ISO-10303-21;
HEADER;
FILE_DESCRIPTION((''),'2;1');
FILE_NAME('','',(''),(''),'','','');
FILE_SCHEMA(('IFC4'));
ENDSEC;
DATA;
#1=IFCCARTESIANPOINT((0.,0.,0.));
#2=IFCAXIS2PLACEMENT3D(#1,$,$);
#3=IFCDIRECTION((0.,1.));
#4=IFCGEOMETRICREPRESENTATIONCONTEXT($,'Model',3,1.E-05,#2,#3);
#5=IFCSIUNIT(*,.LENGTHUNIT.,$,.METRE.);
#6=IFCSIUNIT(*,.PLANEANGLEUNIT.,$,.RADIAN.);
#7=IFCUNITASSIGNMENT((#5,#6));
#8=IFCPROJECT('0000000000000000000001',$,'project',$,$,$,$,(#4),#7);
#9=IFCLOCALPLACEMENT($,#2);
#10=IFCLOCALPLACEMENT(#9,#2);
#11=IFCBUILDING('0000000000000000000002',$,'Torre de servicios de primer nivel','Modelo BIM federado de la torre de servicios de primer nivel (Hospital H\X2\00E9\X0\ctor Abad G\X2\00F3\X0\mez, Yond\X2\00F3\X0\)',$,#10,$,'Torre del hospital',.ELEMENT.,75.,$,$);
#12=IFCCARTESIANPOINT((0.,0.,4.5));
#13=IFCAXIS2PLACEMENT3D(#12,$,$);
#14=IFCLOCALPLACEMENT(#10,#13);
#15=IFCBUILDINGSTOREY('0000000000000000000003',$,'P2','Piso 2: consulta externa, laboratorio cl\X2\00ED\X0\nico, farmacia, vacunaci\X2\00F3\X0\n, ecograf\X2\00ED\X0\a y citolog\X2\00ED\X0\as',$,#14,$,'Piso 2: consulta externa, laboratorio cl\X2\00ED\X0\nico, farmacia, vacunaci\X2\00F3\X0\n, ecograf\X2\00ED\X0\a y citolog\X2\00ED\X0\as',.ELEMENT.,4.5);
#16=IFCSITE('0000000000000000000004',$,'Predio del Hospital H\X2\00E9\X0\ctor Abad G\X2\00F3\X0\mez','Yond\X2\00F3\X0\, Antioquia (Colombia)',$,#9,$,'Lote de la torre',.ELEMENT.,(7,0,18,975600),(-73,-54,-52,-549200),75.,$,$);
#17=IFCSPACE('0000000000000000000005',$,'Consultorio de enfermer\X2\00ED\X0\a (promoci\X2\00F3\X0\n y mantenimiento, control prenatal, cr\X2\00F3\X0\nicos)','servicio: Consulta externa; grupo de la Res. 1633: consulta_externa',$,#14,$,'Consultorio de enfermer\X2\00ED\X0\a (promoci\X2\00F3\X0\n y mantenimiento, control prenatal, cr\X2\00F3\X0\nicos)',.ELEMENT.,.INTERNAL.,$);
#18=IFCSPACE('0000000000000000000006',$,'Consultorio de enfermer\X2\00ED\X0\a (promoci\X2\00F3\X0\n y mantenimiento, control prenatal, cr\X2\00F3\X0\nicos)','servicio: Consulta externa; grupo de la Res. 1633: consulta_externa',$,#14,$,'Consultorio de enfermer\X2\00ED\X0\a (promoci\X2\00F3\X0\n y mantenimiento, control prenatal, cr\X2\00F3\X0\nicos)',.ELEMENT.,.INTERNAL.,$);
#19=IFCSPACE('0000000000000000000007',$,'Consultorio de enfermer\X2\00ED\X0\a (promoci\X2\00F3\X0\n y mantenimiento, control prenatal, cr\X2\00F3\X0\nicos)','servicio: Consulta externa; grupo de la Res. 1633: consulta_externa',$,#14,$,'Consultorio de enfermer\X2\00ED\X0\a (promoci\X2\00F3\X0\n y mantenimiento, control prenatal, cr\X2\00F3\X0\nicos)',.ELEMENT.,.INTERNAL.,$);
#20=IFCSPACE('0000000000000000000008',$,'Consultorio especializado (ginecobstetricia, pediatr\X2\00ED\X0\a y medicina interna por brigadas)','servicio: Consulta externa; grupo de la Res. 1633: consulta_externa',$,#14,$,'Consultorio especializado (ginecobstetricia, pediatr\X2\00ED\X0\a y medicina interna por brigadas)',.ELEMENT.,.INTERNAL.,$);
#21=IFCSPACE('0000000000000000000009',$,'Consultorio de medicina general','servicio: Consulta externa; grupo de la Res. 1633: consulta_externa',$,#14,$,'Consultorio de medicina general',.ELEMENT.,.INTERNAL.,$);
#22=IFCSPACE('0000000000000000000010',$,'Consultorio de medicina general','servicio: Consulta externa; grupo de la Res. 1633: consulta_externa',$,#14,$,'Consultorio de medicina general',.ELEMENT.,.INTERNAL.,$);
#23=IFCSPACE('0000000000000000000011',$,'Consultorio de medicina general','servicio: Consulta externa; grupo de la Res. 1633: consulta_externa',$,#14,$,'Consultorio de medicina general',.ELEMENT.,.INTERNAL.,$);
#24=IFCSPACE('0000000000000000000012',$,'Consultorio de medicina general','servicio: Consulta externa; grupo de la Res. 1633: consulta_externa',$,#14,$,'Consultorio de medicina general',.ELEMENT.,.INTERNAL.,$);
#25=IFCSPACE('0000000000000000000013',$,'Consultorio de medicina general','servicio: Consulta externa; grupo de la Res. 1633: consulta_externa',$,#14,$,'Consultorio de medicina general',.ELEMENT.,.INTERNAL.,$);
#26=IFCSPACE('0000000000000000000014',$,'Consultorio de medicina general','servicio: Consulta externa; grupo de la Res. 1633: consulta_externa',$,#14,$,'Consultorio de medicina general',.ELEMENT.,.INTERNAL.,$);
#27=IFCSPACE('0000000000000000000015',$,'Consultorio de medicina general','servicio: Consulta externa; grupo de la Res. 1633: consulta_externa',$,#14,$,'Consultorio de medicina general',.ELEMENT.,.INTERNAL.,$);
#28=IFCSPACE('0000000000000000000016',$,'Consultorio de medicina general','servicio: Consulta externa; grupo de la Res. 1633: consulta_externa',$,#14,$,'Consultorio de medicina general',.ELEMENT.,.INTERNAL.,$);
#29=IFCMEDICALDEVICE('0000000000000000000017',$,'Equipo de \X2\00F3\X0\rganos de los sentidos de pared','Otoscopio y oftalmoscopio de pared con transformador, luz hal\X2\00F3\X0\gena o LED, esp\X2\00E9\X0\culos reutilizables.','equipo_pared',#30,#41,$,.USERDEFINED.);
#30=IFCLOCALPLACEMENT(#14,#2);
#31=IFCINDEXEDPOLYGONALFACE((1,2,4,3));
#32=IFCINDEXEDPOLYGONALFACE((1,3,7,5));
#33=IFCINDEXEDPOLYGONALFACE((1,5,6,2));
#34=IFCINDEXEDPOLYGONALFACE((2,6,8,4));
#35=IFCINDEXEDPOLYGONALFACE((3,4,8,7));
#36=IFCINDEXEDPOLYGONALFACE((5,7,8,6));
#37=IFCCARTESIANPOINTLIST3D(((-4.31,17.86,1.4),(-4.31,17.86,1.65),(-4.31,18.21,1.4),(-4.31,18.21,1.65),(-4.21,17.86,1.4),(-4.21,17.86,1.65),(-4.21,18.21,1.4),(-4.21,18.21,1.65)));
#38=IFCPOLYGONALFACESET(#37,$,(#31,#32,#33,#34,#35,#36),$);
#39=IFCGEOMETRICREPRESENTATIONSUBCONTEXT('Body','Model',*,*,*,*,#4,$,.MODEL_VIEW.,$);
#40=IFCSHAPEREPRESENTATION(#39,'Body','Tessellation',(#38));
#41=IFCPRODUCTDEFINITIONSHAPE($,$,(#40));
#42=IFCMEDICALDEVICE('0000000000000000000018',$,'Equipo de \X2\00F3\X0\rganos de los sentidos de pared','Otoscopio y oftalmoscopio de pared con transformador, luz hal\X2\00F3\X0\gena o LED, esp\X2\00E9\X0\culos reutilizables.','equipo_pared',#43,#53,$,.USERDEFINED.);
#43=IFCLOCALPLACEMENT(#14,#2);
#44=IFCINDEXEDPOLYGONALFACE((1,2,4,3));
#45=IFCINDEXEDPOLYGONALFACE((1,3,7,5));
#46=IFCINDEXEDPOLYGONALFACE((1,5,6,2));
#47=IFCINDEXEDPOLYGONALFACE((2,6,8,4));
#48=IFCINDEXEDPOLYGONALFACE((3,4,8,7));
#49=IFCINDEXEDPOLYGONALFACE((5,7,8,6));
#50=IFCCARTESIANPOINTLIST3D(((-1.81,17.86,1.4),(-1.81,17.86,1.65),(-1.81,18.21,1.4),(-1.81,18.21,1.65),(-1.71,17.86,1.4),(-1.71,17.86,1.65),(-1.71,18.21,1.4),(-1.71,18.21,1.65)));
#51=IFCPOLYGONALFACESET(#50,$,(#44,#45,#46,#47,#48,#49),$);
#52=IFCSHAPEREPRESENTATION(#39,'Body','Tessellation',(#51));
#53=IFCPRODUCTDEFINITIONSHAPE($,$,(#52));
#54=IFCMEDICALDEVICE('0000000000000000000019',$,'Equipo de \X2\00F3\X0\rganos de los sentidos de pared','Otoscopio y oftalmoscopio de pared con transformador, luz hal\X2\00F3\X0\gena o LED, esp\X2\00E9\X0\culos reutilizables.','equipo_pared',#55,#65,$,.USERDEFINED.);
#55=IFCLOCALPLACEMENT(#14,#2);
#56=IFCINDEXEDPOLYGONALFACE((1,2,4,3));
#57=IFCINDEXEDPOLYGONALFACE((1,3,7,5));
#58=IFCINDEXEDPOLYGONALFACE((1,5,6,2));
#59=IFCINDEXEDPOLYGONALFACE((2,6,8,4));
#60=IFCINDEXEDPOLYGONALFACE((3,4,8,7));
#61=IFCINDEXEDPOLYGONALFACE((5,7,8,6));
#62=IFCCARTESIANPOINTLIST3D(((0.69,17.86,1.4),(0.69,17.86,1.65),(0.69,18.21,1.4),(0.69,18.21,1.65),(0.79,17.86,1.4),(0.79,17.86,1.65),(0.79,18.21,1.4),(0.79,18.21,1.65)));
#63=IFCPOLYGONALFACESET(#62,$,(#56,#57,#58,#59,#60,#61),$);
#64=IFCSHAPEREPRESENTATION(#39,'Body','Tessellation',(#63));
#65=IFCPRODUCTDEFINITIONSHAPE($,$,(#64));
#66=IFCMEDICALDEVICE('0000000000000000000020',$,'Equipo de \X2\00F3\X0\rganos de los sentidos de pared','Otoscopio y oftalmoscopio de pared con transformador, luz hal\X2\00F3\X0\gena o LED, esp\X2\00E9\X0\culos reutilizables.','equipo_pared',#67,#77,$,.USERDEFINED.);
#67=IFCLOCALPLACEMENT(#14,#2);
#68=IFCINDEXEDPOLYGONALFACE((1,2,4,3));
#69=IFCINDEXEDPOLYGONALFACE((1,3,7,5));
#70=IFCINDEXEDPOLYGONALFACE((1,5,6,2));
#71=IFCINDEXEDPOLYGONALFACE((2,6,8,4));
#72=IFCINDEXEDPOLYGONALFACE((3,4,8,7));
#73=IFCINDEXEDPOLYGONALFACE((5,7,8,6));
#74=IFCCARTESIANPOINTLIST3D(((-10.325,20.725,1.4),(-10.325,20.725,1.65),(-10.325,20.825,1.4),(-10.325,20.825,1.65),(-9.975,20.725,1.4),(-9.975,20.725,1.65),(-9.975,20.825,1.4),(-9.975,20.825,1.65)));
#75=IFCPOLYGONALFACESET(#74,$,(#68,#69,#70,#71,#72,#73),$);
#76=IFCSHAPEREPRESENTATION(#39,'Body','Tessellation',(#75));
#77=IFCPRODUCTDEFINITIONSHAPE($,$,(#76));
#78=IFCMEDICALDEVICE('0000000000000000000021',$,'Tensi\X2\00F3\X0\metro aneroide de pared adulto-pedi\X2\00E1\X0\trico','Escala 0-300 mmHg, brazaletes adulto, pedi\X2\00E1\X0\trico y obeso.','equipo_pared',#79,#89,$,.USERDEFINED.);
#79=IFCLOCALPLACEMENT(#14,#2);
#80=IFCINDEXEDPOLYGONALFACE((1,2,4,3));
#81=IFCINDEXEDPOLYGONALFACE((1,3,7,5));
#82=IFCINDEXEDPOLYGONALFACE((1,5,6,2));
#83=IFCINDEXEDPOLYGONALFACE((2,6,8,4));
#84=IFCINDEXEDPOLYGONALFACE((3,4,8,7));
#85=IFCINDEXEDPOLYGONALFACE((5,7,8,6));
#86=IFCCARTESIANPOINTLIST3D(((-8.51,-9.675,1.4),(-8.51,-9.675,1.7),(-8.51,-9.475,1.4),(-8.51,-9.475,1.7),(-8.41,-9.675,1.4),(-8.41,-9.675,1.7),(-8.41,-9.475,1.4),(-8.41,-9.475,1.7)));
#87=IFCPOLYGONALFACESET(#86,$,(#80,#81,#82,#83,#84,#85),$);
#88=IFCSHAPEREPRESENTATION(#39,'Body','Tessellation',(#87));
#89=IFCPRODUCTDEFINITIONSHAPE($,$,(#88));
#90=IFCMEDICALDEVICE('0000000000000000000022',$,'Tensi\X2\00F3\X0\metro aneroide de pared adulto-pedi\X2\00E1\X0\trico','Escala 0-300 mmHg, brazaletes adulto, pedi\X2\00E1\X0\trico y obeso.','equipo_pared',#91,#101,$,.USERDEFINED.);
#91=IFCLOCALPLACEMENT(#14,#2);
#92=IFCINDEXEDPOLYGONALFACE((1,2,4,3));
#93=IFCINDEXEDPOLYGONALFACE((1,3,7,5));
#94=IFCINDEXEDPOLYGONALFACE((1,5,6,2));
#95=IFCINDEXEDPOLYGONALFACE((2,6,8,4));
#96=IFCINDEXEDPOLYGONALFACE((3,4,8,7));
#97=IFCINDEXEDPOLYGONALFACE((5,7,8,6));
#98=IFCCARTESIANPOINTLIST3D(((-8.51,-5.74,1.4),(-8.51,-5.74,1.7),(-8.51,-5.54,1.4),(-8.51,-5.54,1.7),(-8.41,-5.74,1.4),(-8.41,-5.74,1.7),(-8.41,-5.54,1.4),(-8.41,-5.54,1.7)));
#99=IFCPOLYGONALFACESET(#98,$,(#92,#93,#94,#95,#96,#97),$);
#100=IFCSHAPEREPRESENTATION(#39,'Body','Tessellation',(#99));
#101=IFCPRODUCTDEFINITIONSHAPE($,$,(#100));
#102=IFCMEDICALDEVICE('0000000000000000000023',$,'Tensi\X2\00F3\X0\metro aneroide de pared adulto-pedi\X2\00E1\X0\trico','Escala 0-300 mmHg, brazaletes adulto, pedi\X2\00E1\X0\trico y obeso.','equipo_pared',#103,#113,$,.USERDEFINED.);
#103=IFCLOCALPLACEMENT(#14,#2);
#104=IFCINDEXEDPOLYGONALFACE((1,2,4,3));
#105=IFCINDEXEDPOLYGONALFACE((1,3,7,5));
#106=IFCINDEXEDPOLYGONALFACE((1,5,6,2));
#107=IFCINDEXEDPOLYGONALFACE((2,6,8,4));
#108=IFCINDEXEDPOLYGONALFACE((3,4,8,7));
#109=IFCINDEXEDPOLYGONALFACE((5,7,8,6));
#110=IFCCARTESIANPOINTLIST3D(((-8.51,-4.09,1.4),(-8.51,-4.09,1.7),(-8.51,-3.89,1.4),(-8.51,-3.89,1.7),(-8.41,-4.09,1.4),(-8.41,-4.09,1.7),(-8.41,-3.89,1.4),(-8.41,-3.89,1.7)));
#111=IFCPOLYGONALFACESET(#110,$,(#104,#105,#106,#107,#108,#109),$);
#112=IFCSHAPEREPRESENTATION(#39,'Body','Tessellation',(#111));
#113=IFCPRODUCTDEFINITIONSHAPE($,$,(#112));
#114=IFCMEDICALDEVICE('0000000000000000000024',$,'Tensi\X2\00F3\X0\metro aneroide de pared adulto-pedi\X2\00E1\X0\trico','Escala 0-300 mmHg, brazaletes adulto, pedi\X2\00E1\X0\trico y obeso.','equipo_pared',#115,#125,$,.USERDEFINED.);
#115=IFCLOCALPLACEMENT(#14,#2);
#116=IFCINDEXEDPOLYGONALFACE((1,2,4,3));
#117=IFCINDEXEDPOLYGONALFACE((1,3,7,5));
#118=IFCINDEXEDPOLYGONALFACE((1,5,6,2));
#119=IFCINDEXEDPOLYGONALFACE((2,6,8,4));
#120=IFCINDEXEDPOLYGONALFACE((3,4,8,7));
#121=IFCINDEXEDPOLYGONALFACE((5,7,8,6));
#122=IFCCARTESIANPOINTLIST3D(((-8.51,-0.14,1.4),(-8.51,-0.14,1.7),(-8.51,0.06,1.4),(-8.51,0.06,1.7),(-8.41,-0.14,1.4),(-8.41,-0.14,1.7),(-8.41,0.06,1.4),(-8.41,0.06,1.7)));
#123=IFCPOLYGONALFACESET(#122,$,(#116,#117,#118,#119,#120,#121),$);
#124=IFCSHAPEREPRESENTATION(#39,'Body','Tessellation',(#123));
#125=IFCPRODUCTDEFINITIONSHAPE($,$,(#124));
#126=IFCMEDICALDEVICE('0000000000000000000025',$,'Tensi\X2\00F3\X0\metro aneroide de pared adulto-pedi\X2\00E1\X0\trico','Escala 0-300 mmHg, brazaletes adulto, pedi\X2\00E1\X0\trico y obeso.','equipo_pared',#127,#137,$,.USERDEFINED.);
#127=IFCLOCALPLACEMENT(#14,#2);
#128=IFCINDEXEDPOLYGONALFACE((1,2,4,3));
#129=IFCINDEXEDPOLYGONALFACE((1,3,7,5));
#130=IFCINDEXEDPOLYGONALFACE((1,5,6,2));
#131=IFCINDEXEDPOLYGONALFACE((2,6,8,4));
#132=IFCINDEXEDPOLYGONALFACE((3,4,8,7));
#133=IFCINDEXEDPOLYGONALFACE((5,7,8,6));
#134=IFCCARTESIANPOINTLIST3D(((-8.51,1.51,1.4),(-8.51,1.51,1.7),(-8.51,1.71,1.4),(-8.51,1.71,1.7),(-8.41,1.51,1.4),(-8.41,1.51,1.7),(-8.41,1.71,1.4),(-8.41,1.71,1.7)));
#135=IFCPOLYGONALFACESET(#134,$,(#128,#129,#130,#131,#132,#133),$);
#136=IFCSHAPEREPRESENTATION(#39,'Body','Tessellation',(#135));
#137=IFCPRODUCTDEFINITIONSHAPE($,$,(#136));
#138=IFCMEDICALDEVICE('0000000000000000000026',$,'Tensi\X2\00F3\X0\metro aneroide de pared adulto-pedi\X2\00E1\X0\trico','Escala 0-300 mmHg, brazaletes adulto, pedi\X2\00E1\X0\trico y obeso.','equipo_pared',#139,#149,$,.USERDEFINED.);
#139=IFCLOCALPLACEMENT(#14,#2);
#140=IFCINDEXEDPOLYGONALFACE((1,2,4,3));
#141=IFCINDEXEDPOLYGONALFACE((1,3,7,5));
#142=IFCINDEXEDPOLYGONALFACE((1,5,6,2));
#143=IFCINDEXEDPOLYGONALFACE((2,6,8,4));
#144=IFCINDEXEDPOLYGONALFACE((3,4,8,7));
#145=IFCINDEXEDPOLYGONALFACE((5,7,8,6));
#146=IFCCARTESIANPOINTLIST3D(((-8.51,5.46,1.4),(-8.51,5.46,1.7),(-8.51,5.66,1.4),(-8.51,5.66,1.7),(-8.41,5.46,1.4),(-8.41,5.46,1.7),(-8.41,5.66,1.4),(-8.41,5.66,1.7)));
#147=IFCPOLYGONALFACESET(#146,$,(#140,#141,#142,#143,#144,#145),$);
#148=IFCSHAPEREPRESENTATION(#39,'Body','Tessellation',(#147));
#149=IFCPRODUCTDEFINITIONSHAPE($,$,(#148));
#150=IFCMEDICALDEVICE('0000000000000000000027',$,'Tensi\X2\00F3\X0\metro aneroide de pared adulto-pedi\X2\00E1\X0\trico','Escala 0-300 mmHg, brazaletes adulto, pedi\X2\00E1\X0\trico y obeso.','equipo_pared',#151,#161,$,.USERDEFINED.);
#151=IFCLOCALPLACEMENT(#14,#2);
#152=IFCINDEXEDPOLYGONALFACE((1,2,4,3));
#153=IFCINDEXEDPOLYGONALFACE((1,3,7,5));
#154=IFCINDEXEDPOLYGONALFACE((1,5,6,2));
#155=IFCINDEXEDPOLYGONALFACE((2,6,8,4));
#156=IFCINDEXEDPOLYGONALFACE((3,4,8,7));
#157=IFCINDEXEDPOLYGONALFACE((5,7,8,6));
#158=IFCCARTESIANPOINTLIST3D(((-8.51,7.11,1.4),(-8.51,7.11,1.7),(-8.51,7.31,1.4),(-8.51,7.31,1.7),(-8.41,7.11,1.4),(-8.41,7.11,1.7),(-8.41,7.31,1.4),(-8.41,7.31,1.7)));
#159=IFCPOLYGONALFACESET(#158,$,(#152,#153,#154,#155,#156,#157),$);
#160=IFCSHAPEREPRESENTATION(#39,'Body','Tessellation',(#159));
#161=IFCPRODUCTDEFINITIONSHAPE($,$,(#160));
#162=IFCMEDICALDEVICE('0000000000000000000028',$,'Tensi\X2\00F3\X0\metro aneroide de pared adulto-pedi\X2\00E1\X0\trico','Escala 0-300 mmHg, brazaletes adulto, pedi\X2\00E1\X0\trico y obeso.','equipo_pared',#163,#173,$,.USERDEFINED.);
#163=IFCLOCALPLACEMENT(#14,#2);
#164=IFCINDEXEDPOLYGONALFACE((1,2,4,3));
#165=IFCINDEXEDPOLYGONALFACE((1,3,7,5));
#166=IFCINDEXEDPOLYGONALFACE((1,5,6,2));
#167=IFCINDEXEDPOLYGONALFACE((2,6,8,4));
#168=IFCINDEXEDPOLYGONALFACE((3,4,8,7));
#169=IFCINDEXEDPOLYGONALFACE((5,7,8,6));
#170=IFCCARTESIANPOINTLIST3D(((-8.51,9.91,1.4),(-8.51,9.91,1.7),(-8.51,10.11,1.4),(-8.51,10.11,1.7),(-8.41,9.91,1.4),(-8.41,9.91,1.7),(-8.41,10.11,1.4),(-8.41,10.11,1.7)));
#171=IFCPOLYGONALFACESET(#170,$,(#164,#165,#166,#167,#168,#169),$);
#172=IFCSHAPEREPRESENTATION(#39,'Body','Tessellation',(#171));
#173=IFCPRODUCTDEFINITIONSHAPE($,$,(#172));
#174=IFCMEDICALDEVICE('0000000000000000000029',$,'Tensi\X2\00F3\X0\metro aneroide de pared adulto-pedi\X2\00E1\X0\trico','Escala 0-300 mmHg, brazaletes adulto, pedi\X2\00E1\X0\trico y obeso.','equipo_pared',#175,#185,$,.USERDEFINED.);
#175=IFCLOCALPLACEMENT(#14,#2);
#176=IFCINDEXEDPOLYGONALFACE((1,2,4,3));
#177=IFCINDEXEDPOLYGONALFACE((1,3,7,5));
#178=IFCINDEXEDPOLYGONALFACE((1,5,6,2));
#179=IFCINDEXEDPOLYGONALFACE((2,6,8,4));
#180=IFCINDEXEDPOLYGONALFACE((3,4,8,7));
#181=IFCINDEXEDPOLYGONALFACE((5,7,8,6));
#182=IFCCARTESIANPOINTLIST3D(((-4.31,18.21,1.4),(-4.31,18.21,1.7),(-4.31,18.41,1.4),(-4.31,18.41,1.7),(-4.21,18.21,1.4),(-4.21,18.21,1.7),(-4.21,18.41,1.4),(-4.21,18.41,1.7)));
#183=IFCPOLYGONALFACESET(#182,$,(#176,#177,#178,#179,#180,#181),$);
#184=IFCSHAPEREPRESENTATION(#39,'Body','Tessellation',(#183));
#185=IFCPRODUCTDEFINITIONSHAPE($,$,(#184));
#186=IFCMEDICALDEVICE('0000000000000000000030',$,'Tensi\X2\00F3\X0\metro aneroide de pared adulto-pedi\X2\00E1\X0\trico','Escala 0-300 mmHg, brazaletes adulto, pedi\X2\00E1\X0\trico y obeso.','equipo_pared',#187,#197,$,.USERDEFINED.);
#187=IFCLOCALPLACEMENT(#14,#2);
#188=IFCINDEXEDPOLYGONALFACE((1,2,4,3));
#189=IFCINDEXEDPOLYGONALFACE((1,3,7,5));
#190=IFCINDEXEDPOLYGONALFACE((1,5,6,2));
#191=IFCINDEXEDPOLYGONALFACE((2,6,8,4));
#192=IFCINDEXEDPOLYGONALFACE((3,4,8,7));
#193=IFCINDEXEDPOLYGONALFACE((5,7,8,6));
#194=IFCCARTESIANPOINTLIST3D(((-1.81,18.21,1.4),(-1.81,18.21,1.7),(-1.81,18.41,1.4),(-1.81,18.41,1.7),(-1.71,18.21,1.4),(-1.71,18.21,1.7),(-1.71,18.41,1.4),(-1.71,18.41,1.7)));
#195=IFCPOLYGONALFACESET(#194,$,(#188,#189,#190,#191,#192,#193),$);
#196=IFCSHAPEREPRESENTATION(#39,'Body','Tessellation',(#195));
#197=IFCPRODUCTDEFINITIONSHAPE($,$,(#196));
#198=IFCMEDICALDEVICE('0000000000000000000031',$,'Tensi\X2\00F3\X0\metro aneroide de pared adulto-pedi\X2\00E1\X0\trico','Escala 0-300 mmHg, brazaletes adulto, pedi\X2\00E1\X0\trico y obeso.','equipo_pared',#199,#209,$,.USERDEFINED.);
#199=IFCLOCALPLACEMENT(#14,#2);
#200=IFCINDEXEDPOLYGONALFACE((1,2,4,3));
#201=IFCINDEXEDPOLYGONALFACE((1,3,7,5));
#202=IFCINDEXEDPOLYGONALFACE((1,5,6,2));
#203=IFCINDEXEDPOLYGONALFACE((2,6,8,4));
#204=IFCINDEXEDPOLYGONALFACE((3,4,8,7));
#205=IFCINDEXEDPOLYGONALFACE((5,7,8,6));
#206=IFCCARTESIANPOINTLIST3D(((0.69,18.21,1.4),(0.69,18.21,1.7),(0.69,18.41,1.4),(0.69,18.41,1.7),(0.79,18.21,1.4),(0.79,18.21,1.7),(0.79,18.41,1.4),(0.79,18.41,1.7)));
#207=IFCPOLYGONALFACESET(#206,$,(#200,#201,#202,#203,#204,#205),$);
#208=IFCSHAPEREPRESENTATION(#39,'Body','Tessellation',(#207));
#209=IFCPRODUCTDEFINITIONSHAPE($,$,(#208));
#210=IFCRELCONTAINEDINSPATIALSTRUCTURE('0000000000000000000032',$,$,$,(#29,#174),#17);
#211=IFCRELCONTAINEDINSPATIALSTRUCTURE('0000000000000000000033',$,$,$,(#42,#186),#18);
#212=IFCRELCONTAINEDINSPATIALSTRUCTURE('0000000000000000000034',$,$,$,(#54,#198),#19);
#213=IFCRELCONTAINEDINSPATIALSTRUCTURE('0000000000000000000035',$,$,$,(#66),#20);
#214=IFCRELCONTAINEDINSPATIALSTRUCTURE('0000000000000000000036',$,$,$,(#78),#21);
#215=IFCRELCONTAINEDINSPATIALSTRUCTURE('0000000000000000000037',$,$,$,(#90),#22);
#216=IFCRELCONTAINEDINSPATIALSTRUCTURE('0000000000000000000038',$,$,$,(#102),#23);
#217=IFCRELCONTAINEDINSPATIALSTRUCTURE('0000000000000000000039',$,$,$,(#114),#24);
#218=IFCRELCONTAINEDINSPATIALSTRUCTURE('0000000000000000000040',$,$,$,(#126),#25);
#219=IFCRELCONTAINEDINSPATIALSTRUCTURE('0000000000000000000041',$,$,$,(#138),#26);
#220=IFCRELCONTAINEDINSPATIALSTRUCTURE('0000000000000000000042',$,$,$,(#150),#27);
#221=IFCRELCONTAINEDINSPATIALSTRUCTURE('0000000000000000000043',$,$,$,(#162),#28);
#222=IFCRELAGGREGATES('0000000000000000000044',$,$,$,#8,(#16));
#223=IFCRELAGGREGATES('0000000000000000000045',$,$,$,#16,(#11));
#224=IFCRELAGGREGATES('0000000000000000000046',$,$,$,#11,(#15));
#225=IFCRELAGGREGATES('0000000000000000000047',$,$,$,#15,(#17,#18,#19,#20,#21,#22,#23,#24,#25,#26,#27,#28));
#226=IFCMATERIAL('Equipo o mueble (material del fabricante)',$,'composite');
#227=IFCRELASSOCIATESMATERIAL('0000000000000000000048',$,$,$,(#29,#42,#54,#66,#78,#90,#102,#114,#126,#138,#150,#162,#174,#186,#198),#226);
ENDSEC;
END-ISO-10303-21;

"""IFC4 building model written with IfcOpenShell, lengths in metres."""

from ifc_helpers import new_model, si_unit, direction, frame, origin, place, context, subcontext, project, spatial, rectangle, extrude, material, element, save


model = new_model("IFC4")

# Units and contexts
model_context = context("Model", 3, precision=1e-05, world=origin(), true_north=direction((0.0, 1.0)))
body_context = subcontext(model_context, "Body", "Model", "MODEL_VIEW")
ifc_project = project(units=[si_unit("LENGTHUNIT", "METRE"), si_unit("PLANEANGLEUNIT", "RADIAN")], contexts=[model_context])

# Site, building, storey, space
site_placement = place(None, origin())
site = spatial("IfcSite", under=ifc_project, at=site_placement, Name="Predio del Hospital Héctor Abad Gómez", Description="Yondó, Antioquia (Colombia)", LongName="Lote de la torre", CompositionType="ELEMENT", RefLatitude=(7, 0, 18, 975600), RefLongitude=(-73, -54, -52, -549200), RefElevation=75.0)
building_placement = place(site_placement, origin())
building = spatial("IfcBuilding", under=site, at=building_placement, Name="Torre de servicios de primer nivel", Description="Modelo BIM federado de la torre de servicios de primer nivel (Hospital Héctor Abad Gómez, Yondó)", LongName="Torre del hospital", CompositionType="ELEMENT", ElevationOfRefHeight=75.0)
placement = place(building_placement, frame((0.0, 0.0, 4.5)))
storey = spatial("IfcBuildingStorey", under=building, at=placement, Name="P2", Description="Piso 2: consulta externa, laboratorio clínico, farmacia, vacunación, ecografía y citologías", LongName="Piso 2: consulta externa, laboratorio clínico, farmacia, vacunación, ecografía y citologías", CompositionType="ELEMENT", Elevation=4.5)
space_1 = spatial("IfcSpace", under=storey, at=placement, Name="Consultorio de enfermería (promoción y mantenimiento, control prenatal, crónicos)", Description="servicio: Consulta externa; grupo de la Res. 1633: consulta_externa", LongName="Consultorio de enfermería (promoción y mantenimiento, control prenatal, crónicos)", CompositionType="ELEMENT", PredefinedType="INTERNAL")

# Medical device
ifc_material = material(Name="Equipo o mueble (material del fabricante)", Category="composite")
element("IfcMedicalDevice", 1, at=placement, inside=space_1, material=ifc_material, Name="Equipo de órganos de los sentidos de pared", Description="Otoscopio y oftalmoscopio de pared con transformador, luz halógena o LED, espéculos reutilizables.", ObjectType="equipo_pared", PredefinedType="USERDEFINED", context=body_context, shape_type="SweptSolid", body=[
    extrude(rectangle(XDim=0.35, YDim=0.1), frame((-4.26, 18.035, 1.4), z_axis=(0.0, 0.0, 1.0), x_axis=(0.0, 1.0, 0.0)), (0.0, 0.0, 1.0), 0.25),
])

# Shared definitions
space_2 = spatial("IfcSpace", under=storey, at=placement, Name="Consultorio de enfermería (promoción y mantenimiento, control prenatal, crónicos)", Description="servicio: Consulta externa; grupo de la Res. 1633: consulta_externa", LongName="Consultorio de enfermería (promoción y mantenimiento, control prenatal, crónicos)", CompositionType="ELEMENT", PredefinedType="INTERNAL")

# Medical device
element("IfcMedicalDevice", 2, at=placement, inside=space_2, material=ifc_material, Name="Equipo de órganos de los sentidos de pared", Description="Otoscopio y oftalmoscopio de pared con transformador, luz halógena o LED, espéculos reutilizables.", ObjectType="equipo_pared", PredefinedType="USERDEFINED", context=body_context, shape_type="SweptSolid", body=[
    extrude(rectangle(XDim=0.35, YDim=0.1), frame((-1.76, 18.035, 1.4), z_axis=(0.0, 0.0, 1.0), x_axis=(0.0, 1.0, 0.0)), (0.0, 0.0, 1.0), 0.25),
])

# Shared definitions
space_3 = spatial("IfcSpace", under=storey, at=placement, Name="Consultorio de enfermería (promoción y mantenimiento, control prenatal, crónicos)", Description="servicio: Consulta externa; grupo de la Res. 1633: consulta_externa", LongName="Consultorio de enfermería (promoción y mantenimiento, control prenatal, crónicos)", CompositionType="ELEMENT", PredefinedType="INTERNAL")

# Medical device
element("IfcMedicalDevice", 3, at=placement, inside=space_3, material=ifc_material, Name="Equipo de órganos de los sentidos de pared", Description="Otoscopio y oftalmoscopio de pared con transformador, luz halógena o LED, espéculos reutilizables.", ObjectType="equipo_pared", PredefinedType="USERDEFINED", context=body_context, shape_type="SweptSolid", body=[
    extrude(rectangle(XDim=0.35, YDim=0.1), frame((0.74, 18.035, 1.4), z_axis=(0.0, 0.0, 1.0), x_axis=(0.0, 1.0, 0.0)), (0.0, 0.0, 1.0), 0.25),
])

# Shared definitions
space_4 = spatial("IfcSpace", under=storey, at=placement, Name="Consultorio especializado (ginecobstetricia, pediatría y medicina interna por brigadas)", Description="servicio: Consulta externa; grupo de la Res. 1633: consulta_externa", LongName="Consultorio especializado (ginecobstetricia, pediatría y medicina interna por brigadas)", CompositionType="ELEMENT", PredefinedType="INTERNAL")

# Medical device
element("IfcMedicalDevice", 4, at=placement, inside=space_4, material=ifc_material, Name="Equipo de órganos de los sentidos de pared", Description="Otoscopio y oftalmoscopio de pared con transformador, luz halógena o LED, espéculos reutilizables.", ObjectType="equipo_pared", PredefinedType="USERDEFINED", context=body_context, shape_type="SweptSolid", body=[
    extrude(rectangle(XDim=0.35, YDim=0.1), frame((-10.15, 20.775, 1.4), z_axis=(0.0, 0.0, 1.0), x_axis=(-1.0, 0.0, 0.0)), (0.0, 0.0, 1.0), 0.25),
])

# Shared definitions
space_5 = spatial("IfcSpace", under=storey, at=placement, Name="Consultorio de medicina general", Description="servicio: Consulta externa; grupo de la Res. 1633: consulta_externa", LongName="Consultorio de medicina general", CompositionType="ELEMENT", PredefinedType="INTERNAL")

# Medical device
element("IfcMedicalDevice", 5, at=placement, inside=space_5, material=ifc_material, Name="Tensiómetro aneroide de pared adulto-pediátrico", Description="Escala 0-300 mmHg, brazaletes adulto, pediátrico y obeso.", ObjectType="equipo_pared", PredefinedType="USERDEFINED", context=body_context, shape_type="SweptSolid", body=[
    extrude(rectangle(XDim=0.2, YDim=0.1), frame((-8.46, -9.575, 1.4), z_axis=(0.0, 0.0, 1.0), x_axis=(0.0, 1.0, 0.0)), (0.0, 0.0, 1.0), 0.3),
])

# Shared definitions
space_6 = spatial("IfcSpace", under=storey, at=placement, Name="Consultorio de medicina general", Description="servicio: Consulta externa; grupo de la Res. 1633: consulta_externa", LongName="Consultorio de medicina general", CompositionType="ELEMENT", PredefinedType="INTERNAL")

# Medical device
element("IfcMedicalDevice", 6, at=placement, inside=space_6, material=ifc_material, Name="Tensiómetro aneroide de pared adulto-pediátrico", Description="Escala 0-300 mmHg, brazaletes adulto, pediátrico y obeso.", ObjectType="equipo_pared", PredefinedType="USERDEFINED", context=body_context, shape_type="SweptSolid", body=[
    extrude(rectangle(XDim=0.2, YDim=0.1), frame((-8.46, -5.64, 1.4), z_axis=(0.0, 0.0, 1.0), x_axis=(0.0, 1.0, 0.0)), (0.0, 0.0, 1.0), 0.3),
])

# Shared definitions
space_7 = spatial("IfcSpace", under=storey, at=placement, Name="Consultorio de medicina general", Description="servicio: Consulta externa; grupo de la Res. 1633: consulta_externa", LongName="Consultorio de medicina general", CompositionType="ELEMENT", PredefinedType="INTERNAL")

# Medical device
element("IfcMedicalDevice", 7, at=placement, inside=space_7, material=ifc_material, Name="Tensiómetro aneroide de pared adulto-pediátrico", Description="Escala 0-300 mmHg, brazaletes adulto, pediátrico y obeso.", ObjectType="equipo_pared", PredefinedType="USERDEFINED", context=body_context, shape_type="SweptSolid", body=[
    extrude(rectangle(XDim=0.2, YDim=0.1), frame((-8.46, -3.99, 1.4), z_axis=(0.0, 0.0, 1.0), x_axis=(0.0, 1.0, 0.0)), (0.0, 0.0, 1.0), 0.3),
])

# Shared definitions
space_8 = spatial("IfcSpace", under=storey, at=placement, Name="Consultorio de medicina general", Description="servicio: Consulta externa; grupo de la Res. 1633: consulta_externa", LongName="Consultorio de medicina general", CompositionType="ELEMENT", PredefinedType="INTERNAL")

# Medical device
element("IfcMedicalDevice", 8, at=placement, inside=space_8, material=ifc_material, Name="Tensiómetro aneroide de pared adulto-pediátrico", Description="Escala 0-300 mmHg, brazaletes adulto, pediátrico y obeso.", ObjectType="equipo_pared", PredefinedType="USERDEFINED", context=body_context, shape_type="SweptSolid", body=[
    extrude(rectangle(XDim=0.2, YDim=0.1), frame((-8.46, -0.04, 1.4), z_axis=(0.0, 0.0, 1.0), x_axis=(0.0, 1.0, 0.0)), (0.0, 0.0, 1.0), 0.3),
])

# Shared definitions
space_9 = spatial("IfcSpace", under=storey, at=placement, Name="Consultorio de medicina general", Description="servicio: Consulta externa; grupo de la Res. 1633: consulta_externa", LongName="Consultorio de medicina general", CompositionType="ELEMENT", PredefinedType="INTERNAL")

# Medical device
element("IfcMedicalDevice", 9, at=placement, inside=space_9, material=ifc_material, Name="Tensiómetro aneroide de pared adulto-pediátrico", Description="Escala 0-300 mmHg, brazaletes adulto, pediátrico y obeso.", ObjectType="equipo_pared", PredefinedType="USERDEFINED", context=body_context, shape_type="SweptSolid", body=[
    extrude(rectangle(XDim=0.2, YDim=0.1), frame((-8.46, 1.61, 1.4), z_axis=(0.0, 0.0, 1.0), x_axis=(0.0, 1.0, 0.0)), (0.0, 0.0, 1.0), 0.3),
])

# Shared definitions
space_10 = spatial("IfcSpace", under=storey, at=placement, Name="Consultorio de medicina general", Description="servicio: Consulta externa; grupo de la Res. 1633: consulta_externa", LongName="Consultorio de medicina general", CompositionType="ELEMENT", PredefinedType="INTERNAL")

# Medical device
element("IfcMedicalDevice", 10, at=placement, inside=space_10, material=ifc_material, Name="Tensiómetro aneroide de pared adulto-pediátrico", Description="Escala 0-300 mmHg, brazaletes adulto, pediátrico y obeso.", ObjectType="equipo_pared", PredefinedType="USERDEFINED", context=body_context, shape_type="SweptSolid", body=[
    extrude(rectangle(XDim=0.2, YDim=0.1), frame((-8.46, 5.56, 1.4), z_axis=(0.0, 0.0, 1.0), x_axis=(0.0, 1.0, 0.0)), (0.0, 0.0, 1.0), 0.3),
])

# Shared definitions
space_11 = spatial("IfcSpace", under=storey, at=placement, Name="Consultorio de medicina general", Description="servicio: Consulta externa; grupo de la Res. 1633: consulta_externa", LongName="Consultorio de medicina general", CompositionType="ELEMENT", PredefinedType="INTERNAL")

# Medical device
element("IfcMedicalDevice", 11, at=placement, inside=space_11, material=ifc_material, Name="Tensiómetro aneroide de pared adulto-pediátrico", Description="Escala 0-300 mmHg, brazaletes adulto, pediátrico y obeso.", ObjectType="equipo_pared", PredefinedType="USERDEFINED", context=body_context, shape_type="SweptSolid", body=[
    extrude(rectangle(XDim=0.2, YDim=0.1), frame((-8.46, 7.21, 1.4), z_axis=(0.0, 0.0, 1.0), x_axis=(0.0, 1.0, 0.0)), (0.0, 0.0, 1.0), 0.3),
])

# Shared definitions
space_12 = spatial("IfcSpace", under=storey, at=placement, Name="Consultorio de medicina general", Description="servicio: Consulta externa; grupo de la Res. 1633: consulta_externa", LongName="Consultorio de medicina general", CompositionType="ELEMENT", PredefinedType="INTERNAL")

# Medical devices
element("IfcMedicalDevice", 12, at=placement, inside=space_12, material=ifc_material, Name="Tensiómetro aneroide de pared adulto-pediátrico", Description="Escala 0-300 mmHg, brazaletes adulto, pediátrico y obeso.", ObjectType="equipo_pared", PredefinedType="USERDEFINED", context=body_context, shape_type="SweptSolid", body=[
    extrude(rectangle(XDim=0.2, YDim=0.1), frame((-8.46, 10.01, 1.4), z_axis=(0.0, 0.0, 1.0), x_axis=(0.0, 1.0, 0.0)), (0.0, 0.0, 1.0), 0.3),
])
element("IfcMedicalDevice", 13, at=placement, inside=space_1, material=ifc_material, Name="Tensiómetro aneroide de pared adulto-pediátrico", Description="Escala 0-300 mmHg, brazaletes adulto, pediátrico y obeso.", ObjectType="equipo_pared", PredefinedType="USERDEFINED", context=body_context, shape_type="SweptSolid", body=[
    extrude(rectangle(XDim=0.2, YDim=0.1), frame((-4.26, 18.31, 1.4), z_axis=(0.0, 0.0, 1.0), x_axis=(0.0, 1.0, 0.0)), (0.0, 0.0, 1.0), 0.3),
])
element("IfcMedicalDevice", 14, at=placement, inside=space_2, material=ifc_material, Name="Tensiómetro aneroide de pared adulto-pediátrico", Description="Escala 0-300 mmHg, brazaletes adulto, pediátrico y obeso.", ObjectType="equipo_pared", PredefinedType="USERDEFINED", context=body_context, shape_type="SweptSolid", body=[
    extrude(rectangle(XDim=0.2, YDim=0.1), frame((-1.76, 18.31, 1.4), z_axis=(0.0, 0.0, 1.0), x_axis=(0.0, 1.0, 0.0)), (0.0, 0.0, 1.0), 0.3),
])
element("IfcMedicalDevice", 15, at=placement, inside=space_3, material=ifc_material, Name="Tensiómetro aneroide de pared adulto-pediátrico", Description="Escala 0-300 mmHg, brazaletes adulto, pediátrico y obeso.", ObjectType="equipo_pared", PredefinedType="USERDEFINED", context=body_context, shape_type="SweptSolid", body=[
    extrude(rectangle(XDim=0.2, YDim=0.1), frame((0.74, 18.31, 1.4), z_axis=(0.0, 0.0, 1.0), x_axis=(0.0, 1.0, 0.0)), (0.0, 0.0, 1.0), 0.3),
])

save(model, "model.ifc")
